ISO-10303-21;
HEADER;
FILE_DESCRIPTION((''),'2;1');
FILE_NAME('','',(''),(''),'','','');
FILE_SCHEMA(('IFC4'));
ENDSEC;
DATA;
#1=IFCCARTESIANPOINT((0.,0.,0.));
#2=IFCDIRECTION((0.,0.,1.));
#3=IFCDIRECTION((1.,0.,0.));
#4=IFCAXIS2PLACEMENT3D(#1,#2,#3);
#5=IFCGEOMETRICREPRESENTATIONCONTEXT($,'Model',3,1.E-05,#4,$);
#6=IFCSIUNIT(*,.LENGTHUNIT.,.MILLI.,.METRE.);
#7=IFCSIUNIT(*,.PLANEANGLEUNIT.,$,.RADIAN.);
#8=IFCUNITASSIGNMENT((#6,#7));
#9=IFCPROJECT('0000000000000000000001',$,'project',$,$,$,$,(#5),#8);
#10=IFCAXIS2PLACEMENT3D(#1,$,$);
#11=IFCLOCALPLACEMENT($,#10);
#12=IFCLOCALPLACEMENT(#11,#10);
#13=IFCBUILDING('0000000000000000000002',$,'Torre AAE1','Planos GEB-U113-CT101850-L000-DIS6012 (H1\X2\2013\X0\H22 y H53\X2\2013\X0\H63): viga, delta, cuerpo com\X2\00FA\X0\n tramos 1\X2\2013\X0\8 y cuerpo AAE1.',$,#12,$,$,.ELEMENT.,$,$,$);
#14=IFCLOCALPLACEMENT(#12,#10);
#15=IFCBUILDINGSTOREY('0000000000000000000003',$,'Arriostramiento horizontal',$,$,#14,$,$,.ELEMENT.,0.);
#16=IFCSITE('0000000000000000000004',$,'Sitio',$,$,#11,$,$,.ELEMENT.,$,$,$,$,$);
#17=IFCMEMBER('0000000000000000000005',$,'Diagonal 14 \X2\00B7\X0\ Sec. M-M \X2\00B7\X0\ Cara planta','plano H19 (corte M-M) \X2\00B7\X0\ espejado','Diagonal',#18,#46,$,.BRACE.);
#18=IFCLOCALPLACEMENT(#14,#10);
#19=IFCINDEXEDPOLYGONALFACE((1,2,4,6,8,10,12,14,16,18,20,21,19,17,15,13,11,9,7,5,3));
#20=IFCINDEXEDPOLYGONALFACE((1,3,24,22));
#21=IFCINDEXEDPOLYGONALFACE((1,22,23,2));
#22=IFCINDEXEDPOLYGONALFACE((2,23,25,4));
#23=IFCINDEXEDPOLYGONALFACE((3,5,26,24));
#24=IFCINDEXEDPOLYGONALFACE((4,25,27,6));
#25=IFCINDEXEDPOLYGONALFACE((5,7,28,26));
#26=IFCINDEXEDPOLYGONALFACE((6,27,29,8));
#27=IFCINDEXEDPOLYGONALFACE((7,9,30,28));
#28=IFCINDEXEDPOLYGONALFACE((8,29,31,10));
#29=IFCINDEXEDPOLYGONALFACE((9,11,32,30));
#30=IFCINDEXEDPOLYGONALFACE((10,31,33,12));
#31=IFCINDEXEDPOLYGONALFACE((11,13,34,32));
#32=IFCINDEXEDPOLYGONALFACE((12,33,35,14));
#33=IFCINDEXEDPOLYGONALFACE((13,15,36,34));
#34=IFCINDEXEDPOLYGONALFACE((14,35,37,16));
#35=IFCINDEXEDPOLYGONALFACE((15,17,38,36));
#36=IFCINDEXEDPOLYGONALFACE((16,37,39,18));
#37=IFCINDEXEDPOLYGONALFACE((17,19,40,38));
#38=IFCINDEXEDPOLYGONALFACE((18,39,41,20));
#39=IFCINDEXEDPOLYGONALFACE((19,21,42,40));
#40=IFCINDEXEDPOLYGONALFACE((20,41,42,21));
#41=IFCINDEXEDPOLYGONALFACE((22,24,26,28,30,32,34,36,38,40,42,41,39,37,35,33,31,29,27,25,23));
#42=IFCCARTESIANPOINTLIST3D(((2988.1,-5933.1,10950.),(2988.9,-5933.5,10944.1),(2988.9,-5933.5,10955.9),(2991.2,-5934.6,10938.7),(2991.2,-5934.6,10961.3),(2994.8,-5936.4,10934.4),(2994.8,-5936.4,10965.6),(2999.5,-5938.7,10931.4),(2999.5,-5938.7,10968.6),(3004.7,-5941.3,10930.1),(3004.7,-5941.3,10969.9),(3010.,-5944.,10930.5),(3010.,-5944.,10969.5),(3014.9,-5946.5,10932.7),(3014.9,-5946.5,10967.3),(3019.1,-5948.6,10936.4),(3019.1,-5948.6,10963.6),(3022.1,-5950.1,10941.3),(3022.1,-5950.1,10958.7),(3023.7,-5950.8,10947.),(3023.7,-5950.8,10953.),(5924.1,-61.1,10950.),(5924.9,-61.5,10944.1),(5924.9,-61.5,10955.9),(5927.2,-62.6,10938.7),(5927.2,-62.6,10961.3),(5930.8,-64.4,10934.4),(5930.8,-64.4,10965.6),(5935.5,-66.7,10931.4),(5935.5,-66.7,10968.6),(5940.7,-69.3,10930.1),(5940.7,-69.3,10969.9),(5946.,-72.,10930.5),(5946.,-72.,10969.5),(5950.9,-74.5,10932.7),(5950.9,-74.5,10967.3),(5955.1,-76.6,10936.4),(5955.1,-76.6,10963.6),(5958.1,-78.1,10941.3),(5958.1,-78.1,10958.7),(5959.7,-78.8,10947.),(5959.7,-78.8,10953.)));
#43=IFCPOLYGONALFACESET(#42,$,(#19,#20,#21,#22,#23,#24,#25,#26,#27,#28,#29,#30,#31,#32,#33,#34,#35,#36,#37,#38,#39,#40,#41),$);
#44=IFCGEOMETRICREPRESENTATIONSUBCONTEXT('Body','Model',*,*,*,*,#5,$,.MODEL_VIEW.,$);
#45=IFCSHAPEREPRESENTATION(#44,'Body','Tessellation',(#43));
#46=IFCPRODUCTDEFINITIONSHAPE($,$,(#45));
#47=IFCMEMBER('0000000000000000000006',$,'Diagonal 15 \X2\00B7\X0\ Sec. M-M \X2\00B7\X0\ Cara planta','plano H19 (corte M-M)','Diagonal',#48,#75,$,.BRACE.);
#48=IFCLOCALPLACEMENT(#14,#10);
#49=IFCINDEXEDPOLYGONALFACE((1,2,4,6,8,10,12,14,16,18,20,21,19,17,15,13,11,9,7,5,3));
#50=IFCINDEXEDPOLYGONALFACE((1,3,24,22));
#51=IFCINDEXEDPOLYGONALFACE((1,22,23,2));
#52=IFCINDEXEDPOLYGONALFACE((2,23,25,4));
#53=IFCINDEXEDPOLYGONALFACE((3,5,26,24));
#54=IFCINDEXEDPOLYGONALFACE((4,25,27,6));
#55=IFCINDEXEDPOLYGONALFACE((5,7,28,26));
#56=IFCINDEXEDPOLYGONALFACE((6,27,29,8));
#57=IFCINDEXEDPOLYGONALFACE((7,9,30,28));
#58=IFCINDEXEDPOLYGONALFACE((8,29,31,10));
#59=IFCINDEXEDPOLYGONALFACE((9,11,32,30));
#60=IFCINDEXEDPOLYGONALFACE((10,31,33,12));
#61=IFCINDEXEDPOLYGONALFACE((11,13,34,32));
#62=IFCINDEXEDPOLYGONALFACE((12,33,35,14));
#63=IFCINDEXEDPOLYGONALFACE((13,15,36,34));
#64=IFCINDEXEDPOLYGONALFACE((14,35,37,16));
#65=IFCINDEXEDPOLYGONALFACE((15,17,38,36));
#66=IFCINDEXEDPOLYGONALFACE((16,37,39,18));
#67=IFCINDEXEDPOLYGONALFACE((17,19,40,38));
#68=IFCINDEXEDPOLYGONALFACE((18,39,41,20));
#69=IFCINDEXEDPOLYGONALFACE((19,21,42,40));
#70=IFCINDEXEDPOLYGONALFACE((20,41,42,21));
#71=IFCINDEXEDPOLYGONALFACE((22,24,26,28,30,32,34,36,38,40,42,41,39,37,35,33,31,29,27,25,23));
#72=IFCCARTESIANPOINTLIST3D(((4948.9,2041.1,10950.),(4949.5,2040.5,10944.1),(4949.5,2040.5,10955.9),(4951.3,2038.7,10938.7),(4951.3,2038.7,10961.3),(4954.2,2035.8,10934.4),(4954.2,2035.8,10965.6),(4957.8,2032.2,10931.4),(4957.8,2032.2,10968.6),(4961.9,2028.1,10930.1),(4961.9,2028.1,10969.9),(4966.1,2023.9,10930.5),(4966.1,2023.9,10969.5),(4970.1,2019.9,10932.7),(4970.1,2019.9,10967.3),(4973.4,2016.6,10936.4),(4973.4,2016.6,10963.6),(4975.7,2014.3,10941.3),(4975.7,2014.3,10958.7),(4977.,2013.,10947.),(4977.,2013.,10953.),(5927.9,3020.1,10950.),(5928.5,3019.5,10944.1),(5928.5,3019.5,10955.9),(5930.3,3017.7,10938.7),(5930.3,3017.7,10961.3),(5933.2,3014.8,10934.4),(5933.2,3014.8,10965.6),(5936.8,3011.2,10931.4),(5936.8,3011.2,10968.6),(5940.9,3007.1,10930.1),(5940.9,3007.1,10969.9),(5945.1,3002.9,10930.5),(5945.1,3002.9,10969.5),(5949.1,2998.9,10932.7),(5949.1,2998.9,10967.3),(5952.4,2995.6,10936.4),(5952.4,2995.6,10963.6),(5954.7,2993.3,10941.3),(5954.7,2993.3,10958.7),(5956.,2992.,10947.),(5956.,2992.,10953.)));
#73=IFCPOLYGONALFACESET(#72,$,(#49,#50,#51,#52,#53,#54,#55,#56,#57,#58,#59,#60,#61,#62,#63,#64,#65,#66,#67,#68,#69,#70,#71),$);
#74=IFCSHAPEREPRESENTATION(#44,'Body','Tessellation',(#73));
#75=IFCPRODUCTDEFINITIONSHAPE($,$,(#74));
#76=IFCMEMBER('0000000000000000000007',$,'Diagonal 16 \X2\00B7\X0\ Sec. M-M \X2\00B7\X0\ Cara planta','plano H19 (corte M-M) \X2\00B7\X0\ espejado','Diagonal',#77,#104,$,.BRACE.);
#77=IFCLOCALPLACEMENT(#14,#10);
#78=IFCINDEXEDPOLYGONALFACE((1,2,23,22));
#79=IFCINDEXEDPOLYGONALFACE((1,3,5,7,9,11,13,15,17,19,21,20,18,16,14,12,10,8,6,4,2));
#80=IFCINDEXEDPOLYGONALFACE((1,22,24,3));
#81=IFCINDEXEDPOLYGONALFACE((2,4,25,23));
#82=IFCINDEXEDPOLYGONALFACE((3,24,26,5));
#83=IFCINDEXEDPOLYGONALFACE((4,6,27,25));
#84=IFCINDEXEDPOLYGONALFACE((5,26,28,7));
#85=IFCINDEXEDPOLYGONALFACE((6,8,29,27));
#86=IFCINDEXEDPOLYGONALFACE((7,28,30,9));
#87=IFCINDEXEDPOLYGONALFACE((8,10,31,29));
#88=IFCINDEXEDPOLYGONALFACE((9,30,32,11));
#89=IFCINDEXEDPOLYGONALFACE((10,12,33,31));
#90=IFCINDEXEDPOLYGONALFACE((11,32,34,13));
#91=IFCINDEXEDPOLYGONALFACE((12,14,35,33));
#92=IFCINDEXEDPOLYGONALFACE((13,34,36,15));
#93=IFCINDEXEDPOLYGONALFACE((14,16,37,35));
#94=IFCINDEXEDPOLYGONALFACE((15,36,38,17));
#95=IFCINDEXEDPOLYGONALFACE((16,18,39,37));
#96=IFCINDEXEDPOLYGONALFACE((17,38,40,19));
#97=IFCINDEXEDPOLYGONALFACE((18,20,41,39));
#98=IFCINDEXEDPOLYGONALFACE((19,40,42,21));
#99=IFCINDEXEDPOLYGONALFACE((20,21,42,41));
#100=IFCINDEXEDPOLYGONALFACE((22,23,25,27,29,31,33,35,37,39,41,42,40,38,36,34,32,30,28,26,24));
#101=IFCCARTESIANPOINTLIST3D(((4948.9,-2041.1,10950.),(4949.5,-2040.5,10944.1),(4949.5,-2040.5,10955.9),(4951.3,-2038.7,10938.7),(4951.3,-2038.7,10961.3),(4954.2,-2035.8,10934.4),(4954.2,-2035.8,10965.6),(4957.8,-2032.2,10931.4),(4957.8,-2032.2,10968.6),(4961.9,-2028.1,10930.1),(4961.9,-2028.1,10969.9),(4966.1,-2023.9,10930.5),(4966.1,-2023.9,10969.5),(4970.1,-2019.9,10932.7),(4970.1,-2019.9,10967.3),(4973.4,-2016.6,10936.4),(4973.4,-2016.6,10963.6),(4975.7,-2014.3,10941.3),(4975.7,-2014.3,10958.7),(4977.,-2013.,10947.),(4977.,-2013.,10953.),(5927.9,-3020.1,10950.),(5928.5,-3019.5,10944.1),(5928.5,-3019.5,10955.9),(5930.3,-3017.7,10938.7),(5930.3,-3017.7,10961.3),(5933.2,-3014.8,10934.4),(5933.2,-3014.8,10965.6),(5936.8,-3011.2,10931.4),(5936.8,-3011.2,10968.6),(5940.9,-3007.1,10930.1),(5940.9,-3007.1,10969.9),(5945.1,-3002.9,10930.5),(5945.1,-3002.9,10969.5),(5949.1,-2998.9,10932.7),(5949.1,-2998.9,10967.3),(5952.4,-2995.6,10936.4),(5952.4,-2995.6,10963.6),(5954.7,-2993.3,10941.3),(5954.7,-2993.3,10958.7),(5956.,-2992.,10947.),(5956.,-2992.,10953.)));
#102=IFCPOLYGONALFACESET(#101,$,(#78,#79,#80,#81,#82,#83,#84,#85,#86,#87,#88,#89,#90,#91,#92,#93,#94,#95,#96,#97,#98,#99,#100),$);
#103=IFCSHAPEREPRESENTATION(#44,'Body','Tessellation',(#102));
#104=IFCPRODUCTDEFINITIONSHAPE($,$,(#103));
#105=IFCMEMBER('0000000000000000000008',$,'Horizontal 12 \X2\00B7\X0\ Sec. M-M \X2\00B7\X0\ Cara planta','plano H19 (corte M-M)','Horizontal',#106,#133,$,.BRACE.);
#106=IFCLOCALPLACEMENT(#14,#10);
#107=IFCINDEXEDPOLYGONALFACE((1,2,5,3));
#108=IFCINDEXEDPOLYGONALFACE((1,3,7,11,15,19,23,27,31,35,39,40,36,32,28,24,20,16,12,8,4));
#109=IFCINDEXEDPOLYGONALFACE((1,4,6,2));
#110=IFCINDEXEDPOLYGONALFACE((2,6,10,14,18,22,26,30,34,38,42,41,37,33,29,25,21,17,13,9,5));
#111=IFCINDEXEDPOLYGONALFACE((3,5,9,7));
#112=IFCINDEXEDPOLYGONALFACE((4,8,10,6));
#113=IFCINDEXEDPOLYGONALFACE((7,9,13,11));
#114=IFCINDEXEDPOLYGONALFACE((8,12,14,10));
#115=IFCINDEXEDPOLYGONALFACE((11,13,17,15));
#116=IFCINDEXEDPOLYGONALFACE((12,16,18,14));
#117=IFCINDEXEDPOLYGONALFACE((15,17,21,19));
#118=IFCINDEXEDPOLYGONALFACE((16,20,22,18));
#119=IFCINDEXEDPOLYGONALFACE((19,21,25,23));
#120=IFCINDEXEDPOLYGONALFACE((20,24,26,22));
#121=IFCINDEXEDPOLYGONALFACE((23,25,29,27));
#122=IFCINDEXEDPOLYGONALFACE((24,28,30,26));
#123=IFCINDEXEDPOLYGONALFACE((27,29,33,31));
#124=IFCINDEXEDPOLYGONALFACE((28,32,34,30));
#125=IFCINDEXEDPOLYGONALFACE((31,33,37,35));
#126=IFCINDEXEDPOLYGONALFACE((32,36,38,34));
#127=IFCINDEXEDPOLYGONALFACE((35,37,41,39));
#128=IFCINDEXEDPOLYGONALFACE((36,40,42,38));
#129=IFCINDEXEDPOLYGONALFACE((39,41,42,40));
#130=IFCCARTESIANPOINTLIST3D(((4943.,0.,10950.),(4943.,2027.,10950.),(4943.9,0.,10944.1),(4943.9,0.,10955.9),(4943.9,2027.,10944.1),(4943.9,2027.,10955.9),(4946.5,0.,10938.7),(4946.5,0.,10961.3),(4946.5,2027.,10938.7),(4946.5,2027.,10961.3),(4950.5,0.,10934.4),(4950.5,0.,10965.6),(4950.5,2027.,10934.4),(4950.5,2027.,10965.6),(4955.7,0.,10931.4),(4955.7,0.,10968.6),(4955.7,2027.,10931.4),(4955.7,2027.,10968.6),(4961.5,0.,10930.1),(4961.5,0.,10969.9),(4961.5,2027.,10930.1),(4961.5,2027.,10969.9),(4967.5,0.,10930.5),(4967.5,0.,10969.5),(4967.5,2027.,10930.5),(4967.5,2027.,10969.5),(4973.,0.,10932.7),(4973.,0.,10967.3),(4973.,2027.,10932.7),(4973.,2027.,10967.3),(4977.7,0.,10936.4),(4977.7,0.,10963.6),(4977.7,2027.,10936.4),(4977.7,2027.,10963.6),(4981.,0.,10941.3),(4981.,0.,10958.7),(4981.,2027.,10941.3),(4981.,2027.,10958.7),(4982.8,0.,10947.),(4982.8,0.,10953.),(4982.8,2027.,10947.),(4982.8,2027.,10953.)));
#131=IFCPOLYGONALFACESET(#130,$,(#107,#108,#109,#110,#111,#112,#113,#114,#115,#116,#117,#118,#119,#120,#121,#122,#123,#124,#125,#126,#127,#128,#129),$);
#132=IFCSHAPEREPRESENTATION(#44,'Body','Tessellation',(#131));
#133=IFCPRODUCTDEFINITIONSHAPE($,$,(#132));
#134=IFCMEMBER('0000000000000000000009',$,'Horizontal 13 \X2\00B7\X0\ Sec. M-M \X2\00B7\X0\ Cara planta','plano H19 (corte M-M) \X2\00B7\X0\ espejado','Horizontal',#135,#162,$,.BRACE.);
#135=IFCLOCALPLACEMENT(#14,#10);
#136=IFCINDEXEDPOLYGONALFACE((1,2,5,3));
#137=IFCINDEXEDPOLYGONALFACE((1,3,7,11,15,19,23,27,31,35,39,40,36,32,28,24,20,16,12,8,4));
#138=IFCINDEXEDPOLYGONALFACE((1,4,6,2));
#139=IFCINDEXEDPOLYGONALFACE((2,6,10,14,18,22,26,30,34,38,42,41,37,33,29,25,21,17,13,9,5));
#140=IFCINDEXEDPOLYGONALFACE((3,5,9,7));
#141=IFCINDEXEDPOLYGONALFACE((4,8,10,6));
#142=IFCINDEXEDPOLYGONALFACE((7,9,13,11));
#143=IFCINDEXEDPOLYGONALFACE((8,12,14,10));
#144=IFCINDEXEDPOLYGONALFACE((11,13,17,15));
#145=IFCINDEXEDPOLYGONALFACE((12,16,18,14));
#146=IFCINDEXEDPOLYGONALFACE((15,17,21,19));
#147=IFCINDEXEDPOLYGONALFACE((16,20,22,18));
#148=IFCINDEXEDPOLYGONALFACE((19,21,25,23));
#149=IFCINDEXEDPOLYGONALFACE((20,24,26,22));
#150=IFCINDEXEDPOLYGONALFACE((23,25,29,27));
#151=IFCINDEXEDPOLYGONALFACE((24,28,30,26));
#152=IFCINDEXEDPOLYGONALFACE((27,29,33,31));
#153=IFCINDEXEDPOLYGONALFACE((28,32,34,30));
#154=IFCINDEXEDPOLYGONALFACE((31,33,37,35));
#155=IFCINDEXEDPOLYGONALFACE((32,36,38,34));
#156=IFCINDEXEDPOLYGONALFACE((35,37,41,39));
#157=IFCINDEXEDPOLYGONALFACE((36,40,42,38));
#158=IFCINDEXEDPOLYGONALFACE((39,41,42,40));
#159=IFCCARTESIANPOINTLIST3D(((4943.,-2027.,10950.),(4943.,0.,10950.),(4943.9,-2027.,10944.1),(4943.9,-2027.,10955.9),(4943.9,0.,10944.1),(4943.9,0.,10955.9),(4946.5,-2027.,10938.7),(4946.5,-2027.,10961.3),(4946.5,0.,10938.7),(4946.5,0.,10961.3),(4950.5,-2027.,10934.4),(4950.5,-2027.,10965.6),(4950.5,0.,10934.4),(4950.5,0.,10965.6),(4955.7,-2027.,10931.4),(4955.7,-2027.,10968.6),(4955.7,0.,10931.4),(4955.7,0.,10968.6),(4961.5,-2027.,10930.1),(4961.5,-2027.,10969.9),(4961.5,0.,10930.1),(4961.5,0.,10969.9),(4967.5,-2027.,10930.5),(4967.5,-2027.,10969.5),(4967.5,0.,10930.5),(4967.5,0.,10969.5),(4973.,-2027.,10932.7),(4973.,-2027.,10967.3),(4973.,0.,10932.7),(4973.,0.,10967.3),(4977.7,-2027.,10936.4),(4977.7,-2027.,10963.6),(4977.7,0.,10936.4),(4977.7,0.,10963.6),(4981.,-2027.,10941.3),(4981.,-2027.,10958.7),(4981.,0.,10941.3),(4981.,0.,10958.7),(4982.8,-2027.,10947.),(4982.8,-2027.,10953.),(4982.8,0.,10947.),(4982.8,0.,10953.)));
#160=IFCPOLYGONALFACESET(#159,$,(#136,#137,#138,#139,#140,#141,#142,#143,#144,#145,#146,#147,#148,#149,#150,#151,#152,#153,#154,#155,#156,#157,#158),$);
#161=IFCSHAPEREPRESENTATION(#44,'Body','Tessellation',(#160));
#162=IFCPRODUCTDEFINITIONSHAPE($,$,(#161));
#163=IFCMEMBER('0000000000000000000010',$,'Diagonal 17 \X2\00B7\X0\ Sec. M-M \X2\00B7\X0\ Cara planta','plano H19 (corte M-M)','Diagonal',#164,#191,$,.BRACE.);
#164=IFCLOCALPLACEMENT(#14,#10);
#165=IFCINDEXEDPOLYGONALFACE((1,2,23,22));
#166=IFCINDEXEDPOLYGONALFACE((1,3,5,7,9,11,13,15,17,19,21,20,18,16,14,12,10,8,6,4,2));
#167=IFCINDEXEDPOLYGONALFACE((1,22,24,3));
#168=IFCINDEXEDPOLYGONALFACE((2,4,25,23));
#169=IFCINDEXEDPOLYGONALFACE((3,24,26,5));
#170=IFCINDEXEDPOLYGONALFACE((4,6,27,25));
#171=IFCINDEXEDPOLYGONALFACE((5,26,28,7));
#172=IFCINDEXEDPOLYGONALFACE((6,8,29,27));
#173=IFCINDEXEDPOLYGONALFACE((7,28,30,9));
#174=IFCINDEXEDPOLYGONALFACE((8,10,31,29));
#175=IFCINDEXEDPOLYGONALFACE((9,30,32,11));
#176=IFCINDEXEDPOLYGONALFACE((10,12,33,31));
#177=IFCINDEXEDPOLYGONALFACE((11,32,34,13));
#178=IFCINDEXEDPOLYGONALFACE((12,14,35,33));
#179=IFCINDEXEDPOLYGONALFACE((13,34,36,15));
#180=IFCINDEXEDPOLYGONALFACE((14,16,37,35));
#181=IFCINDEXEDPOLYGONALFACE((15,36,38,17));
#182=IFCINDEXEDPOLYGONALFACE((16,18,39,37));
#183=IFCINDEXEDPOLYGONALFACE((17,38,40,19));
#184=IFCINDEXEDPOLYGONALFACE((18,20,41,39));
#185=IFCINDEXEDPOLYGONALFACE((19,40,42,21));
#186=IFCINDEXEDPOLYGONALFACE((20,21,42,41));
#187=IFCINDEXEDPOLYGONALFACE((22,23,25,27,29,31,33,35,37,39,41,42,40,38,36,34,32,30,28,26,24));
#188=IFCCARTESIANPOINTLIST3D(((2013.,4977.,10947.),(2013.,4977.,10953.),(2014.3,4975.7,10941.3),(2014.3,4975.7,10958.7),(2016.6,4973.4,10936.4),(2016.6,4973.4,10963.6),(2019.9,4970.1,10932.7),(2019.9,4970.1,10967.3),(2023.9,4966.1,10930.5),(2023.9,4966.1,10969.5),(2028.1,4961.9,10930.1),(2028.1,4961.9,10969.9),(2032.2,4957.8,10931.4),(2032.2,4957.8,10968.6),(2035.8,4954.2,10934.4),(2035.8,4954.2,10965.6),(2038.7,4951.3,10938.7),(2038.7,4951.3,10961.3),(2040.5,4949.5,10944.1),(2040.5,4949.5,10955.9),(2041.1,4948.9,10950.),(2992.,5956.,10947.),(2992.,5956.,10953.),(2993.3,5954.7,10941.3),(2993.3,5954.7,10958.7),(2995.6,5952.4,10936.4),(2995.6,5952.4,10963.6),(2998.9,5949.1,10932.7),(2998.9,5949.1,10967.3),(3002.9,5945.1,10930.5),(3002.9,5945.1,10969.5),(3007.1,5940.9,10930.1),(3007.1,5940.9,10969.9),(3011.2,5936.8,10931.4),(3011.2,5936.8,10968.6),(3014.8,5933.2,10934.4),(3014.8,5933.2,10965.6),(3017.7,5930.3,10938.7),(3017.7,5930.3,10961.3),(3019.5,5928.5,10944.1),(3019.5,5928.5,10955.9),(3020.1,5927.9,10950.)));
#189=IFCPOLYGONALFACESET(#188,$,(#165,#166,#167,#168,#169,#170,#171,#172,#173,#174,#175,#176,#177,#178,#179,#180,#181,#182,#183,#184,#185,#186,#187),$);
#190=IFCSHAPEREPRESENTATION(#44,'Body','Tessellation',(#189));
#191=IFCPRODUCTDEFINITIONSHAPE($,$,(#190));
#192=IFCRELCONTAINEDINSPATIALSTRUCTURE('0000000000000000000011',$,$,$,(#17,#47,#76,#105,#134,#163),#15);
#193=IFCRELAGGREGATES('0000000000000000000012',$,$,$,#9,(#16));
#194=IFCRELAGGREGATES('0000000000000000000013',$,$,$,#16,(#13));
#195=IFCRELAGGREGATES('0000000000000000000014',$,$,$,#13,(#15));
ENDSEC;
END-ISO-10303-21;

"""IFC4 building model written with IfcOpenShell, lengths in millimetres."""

from ifc_helpers import new_model, si_unit, frame, origin, origin_with_axes, place, context, subcontext, project, spatial, circle, extrude, element, save


model = new_model("IFC4")

# Units and contexts
model_context = context("Model", 3, precision=1e-05, world=origin_with_axes())
body_context = subcontext(model_context, "Body", "Model", "MODEL_VIEW")
ifc_project = project(units=[si_unit("LENGTHUNIT", "METRE", prefix="MILLI"), si_unit("PLANEANGLEUNIT", "RADIAN")], contexts=[model_context])

# Site, building, storey
site_placement = place(None, origin())
site = spatial("IfcSite", under=ifc_project, at=site_placement, Name="Sitio", CompositionType="ELEMENT")
building_placement = place(site_placement, origin())
building = spatial("IfcBuilding", under=site, at=building_placement, Name="Torre AAE1", Description="Planos GEB-U113-CT101850-L000-DIS6012 (H1–H22 y H53–H63): viga, delta, cuerpo común tramos 1–8 y cuerpo AAE1.", CompositionType="ELEMENT")
storey_placement = place(building_placement, origin())
storey = spatial("IfcBuildingStorey", under=building, at=storey_placement, Name="Arriostramiento horizontal", CompositionType="ELEMENT", Elevation=0.0)

# Members
for number, where, z_axis, x_axis, name in (
    (1, (5942.0, -70.0, 10950.0), (-0.447214, -0.894427, 0.0), (-0.894427, 0.447214, 0.0), "Diagonal 14 · Sec. M-M · Cara planta"),
):
    element("IfcMember", number, at=place(storey_placement, frame(where, z_axis=z_axis, x_axis=x_axis)), inside=storey, Name=name, Description="plano H19 (corte M-M) · espejado", ObjectType="Diagonal", PredefinedType="BRACE", context=body_context, shape_type="SweptSolid", body=[
        extrude(circle(Radius=20.0), None, (0.0, 0.0, 1.0), 6565.1),
    ])
for number, where, z_axis, x_axis, name, description in (
    (2, (5942.0, 3006.0, 10950.0), (-0.707107, -0.707107, 0.0), (-0.707107, 0.707107, 0.0), "Diagonal 15 · Sec. M-M · Cara planta", "plano H19 (corte M-M)"),
    (3, (5942.0, -3006.0, 10950.0), (-0.707107, 0.707107, 0.0), (-0.707107, -0.707107, 0.0), "Diagonal 16 · Sec. M-M · Cara planta", "plano H19 (corte M-M) · espejado"),
):
    element("IfcMember", number, at=place(storey_placement, frame(where, z_axis=z_axis, x_axis=x_axis)), inside=storey, Name=name, Description=description, ObjectType="Diagonal", PredefinedType="BRACE", context=body_context, shape_type="SweptSolid", body=[
        extrude(circle(Radius=20.0), None, (0.0, 0.0, 1.0), 1384.5),
    ])
for number, where, z_axis, x_axis, name, description in (
    (4, (4963.0, 2027.0, 10950.0), (0.0, -1.0, 0.0), (-1.0, 0.0, 0.0), "Horizontal 12 · Sec. M-M · Cara planta", "plano H19 (corte M-M)"),
    (5, (4963.0, -2027.0, 10950.0), (0.0, 1.0, 0.0), (-1.0, 0.0, 0.0), "Horizontal 13 · Sec. M-M · Cara planta", "plano H19 (corte M-M) · espejado"),
):
    element("IfcMember", number, at=place(storey_placement, frame(where, z_axis=z_axis, x_axis=x_axis)), inside=storey, Name=name, Description=description, ObjectType="Horizontal", PredefinedType="BRACE", context=body_context, shape_type="SweptSolid", body=[
        extrude(circle(Radius=20.0), None, (0.0, 0.0, 1.0), 2027.0),
    ])
for number, where, z_axis, x_axis, name in (
    (6, (3006.0, 5942.0, 10950.0), (-0.707107, -0.707107, 0.0), (0.707107, -0.707107, 0.0), "Diagonal 17 · Sec. M-M · Cara planta"),
):
    element("IfcMember", number, at=place(storey_placement, frame(where, z_axis=z_axis, x_axis=x_axis)), inside=storey, Name=name, Description="plano H19 (corte M-M)", ObjectType="Diagonal", PredefinedType="BRACE", context=body_context, shape_type="SweptSolid", body=[
        extrude(circle(Radius=20.0), None, (0.0, 0.0, 1.0), 1384.5),
    ])

save(model, "model.ifc")
